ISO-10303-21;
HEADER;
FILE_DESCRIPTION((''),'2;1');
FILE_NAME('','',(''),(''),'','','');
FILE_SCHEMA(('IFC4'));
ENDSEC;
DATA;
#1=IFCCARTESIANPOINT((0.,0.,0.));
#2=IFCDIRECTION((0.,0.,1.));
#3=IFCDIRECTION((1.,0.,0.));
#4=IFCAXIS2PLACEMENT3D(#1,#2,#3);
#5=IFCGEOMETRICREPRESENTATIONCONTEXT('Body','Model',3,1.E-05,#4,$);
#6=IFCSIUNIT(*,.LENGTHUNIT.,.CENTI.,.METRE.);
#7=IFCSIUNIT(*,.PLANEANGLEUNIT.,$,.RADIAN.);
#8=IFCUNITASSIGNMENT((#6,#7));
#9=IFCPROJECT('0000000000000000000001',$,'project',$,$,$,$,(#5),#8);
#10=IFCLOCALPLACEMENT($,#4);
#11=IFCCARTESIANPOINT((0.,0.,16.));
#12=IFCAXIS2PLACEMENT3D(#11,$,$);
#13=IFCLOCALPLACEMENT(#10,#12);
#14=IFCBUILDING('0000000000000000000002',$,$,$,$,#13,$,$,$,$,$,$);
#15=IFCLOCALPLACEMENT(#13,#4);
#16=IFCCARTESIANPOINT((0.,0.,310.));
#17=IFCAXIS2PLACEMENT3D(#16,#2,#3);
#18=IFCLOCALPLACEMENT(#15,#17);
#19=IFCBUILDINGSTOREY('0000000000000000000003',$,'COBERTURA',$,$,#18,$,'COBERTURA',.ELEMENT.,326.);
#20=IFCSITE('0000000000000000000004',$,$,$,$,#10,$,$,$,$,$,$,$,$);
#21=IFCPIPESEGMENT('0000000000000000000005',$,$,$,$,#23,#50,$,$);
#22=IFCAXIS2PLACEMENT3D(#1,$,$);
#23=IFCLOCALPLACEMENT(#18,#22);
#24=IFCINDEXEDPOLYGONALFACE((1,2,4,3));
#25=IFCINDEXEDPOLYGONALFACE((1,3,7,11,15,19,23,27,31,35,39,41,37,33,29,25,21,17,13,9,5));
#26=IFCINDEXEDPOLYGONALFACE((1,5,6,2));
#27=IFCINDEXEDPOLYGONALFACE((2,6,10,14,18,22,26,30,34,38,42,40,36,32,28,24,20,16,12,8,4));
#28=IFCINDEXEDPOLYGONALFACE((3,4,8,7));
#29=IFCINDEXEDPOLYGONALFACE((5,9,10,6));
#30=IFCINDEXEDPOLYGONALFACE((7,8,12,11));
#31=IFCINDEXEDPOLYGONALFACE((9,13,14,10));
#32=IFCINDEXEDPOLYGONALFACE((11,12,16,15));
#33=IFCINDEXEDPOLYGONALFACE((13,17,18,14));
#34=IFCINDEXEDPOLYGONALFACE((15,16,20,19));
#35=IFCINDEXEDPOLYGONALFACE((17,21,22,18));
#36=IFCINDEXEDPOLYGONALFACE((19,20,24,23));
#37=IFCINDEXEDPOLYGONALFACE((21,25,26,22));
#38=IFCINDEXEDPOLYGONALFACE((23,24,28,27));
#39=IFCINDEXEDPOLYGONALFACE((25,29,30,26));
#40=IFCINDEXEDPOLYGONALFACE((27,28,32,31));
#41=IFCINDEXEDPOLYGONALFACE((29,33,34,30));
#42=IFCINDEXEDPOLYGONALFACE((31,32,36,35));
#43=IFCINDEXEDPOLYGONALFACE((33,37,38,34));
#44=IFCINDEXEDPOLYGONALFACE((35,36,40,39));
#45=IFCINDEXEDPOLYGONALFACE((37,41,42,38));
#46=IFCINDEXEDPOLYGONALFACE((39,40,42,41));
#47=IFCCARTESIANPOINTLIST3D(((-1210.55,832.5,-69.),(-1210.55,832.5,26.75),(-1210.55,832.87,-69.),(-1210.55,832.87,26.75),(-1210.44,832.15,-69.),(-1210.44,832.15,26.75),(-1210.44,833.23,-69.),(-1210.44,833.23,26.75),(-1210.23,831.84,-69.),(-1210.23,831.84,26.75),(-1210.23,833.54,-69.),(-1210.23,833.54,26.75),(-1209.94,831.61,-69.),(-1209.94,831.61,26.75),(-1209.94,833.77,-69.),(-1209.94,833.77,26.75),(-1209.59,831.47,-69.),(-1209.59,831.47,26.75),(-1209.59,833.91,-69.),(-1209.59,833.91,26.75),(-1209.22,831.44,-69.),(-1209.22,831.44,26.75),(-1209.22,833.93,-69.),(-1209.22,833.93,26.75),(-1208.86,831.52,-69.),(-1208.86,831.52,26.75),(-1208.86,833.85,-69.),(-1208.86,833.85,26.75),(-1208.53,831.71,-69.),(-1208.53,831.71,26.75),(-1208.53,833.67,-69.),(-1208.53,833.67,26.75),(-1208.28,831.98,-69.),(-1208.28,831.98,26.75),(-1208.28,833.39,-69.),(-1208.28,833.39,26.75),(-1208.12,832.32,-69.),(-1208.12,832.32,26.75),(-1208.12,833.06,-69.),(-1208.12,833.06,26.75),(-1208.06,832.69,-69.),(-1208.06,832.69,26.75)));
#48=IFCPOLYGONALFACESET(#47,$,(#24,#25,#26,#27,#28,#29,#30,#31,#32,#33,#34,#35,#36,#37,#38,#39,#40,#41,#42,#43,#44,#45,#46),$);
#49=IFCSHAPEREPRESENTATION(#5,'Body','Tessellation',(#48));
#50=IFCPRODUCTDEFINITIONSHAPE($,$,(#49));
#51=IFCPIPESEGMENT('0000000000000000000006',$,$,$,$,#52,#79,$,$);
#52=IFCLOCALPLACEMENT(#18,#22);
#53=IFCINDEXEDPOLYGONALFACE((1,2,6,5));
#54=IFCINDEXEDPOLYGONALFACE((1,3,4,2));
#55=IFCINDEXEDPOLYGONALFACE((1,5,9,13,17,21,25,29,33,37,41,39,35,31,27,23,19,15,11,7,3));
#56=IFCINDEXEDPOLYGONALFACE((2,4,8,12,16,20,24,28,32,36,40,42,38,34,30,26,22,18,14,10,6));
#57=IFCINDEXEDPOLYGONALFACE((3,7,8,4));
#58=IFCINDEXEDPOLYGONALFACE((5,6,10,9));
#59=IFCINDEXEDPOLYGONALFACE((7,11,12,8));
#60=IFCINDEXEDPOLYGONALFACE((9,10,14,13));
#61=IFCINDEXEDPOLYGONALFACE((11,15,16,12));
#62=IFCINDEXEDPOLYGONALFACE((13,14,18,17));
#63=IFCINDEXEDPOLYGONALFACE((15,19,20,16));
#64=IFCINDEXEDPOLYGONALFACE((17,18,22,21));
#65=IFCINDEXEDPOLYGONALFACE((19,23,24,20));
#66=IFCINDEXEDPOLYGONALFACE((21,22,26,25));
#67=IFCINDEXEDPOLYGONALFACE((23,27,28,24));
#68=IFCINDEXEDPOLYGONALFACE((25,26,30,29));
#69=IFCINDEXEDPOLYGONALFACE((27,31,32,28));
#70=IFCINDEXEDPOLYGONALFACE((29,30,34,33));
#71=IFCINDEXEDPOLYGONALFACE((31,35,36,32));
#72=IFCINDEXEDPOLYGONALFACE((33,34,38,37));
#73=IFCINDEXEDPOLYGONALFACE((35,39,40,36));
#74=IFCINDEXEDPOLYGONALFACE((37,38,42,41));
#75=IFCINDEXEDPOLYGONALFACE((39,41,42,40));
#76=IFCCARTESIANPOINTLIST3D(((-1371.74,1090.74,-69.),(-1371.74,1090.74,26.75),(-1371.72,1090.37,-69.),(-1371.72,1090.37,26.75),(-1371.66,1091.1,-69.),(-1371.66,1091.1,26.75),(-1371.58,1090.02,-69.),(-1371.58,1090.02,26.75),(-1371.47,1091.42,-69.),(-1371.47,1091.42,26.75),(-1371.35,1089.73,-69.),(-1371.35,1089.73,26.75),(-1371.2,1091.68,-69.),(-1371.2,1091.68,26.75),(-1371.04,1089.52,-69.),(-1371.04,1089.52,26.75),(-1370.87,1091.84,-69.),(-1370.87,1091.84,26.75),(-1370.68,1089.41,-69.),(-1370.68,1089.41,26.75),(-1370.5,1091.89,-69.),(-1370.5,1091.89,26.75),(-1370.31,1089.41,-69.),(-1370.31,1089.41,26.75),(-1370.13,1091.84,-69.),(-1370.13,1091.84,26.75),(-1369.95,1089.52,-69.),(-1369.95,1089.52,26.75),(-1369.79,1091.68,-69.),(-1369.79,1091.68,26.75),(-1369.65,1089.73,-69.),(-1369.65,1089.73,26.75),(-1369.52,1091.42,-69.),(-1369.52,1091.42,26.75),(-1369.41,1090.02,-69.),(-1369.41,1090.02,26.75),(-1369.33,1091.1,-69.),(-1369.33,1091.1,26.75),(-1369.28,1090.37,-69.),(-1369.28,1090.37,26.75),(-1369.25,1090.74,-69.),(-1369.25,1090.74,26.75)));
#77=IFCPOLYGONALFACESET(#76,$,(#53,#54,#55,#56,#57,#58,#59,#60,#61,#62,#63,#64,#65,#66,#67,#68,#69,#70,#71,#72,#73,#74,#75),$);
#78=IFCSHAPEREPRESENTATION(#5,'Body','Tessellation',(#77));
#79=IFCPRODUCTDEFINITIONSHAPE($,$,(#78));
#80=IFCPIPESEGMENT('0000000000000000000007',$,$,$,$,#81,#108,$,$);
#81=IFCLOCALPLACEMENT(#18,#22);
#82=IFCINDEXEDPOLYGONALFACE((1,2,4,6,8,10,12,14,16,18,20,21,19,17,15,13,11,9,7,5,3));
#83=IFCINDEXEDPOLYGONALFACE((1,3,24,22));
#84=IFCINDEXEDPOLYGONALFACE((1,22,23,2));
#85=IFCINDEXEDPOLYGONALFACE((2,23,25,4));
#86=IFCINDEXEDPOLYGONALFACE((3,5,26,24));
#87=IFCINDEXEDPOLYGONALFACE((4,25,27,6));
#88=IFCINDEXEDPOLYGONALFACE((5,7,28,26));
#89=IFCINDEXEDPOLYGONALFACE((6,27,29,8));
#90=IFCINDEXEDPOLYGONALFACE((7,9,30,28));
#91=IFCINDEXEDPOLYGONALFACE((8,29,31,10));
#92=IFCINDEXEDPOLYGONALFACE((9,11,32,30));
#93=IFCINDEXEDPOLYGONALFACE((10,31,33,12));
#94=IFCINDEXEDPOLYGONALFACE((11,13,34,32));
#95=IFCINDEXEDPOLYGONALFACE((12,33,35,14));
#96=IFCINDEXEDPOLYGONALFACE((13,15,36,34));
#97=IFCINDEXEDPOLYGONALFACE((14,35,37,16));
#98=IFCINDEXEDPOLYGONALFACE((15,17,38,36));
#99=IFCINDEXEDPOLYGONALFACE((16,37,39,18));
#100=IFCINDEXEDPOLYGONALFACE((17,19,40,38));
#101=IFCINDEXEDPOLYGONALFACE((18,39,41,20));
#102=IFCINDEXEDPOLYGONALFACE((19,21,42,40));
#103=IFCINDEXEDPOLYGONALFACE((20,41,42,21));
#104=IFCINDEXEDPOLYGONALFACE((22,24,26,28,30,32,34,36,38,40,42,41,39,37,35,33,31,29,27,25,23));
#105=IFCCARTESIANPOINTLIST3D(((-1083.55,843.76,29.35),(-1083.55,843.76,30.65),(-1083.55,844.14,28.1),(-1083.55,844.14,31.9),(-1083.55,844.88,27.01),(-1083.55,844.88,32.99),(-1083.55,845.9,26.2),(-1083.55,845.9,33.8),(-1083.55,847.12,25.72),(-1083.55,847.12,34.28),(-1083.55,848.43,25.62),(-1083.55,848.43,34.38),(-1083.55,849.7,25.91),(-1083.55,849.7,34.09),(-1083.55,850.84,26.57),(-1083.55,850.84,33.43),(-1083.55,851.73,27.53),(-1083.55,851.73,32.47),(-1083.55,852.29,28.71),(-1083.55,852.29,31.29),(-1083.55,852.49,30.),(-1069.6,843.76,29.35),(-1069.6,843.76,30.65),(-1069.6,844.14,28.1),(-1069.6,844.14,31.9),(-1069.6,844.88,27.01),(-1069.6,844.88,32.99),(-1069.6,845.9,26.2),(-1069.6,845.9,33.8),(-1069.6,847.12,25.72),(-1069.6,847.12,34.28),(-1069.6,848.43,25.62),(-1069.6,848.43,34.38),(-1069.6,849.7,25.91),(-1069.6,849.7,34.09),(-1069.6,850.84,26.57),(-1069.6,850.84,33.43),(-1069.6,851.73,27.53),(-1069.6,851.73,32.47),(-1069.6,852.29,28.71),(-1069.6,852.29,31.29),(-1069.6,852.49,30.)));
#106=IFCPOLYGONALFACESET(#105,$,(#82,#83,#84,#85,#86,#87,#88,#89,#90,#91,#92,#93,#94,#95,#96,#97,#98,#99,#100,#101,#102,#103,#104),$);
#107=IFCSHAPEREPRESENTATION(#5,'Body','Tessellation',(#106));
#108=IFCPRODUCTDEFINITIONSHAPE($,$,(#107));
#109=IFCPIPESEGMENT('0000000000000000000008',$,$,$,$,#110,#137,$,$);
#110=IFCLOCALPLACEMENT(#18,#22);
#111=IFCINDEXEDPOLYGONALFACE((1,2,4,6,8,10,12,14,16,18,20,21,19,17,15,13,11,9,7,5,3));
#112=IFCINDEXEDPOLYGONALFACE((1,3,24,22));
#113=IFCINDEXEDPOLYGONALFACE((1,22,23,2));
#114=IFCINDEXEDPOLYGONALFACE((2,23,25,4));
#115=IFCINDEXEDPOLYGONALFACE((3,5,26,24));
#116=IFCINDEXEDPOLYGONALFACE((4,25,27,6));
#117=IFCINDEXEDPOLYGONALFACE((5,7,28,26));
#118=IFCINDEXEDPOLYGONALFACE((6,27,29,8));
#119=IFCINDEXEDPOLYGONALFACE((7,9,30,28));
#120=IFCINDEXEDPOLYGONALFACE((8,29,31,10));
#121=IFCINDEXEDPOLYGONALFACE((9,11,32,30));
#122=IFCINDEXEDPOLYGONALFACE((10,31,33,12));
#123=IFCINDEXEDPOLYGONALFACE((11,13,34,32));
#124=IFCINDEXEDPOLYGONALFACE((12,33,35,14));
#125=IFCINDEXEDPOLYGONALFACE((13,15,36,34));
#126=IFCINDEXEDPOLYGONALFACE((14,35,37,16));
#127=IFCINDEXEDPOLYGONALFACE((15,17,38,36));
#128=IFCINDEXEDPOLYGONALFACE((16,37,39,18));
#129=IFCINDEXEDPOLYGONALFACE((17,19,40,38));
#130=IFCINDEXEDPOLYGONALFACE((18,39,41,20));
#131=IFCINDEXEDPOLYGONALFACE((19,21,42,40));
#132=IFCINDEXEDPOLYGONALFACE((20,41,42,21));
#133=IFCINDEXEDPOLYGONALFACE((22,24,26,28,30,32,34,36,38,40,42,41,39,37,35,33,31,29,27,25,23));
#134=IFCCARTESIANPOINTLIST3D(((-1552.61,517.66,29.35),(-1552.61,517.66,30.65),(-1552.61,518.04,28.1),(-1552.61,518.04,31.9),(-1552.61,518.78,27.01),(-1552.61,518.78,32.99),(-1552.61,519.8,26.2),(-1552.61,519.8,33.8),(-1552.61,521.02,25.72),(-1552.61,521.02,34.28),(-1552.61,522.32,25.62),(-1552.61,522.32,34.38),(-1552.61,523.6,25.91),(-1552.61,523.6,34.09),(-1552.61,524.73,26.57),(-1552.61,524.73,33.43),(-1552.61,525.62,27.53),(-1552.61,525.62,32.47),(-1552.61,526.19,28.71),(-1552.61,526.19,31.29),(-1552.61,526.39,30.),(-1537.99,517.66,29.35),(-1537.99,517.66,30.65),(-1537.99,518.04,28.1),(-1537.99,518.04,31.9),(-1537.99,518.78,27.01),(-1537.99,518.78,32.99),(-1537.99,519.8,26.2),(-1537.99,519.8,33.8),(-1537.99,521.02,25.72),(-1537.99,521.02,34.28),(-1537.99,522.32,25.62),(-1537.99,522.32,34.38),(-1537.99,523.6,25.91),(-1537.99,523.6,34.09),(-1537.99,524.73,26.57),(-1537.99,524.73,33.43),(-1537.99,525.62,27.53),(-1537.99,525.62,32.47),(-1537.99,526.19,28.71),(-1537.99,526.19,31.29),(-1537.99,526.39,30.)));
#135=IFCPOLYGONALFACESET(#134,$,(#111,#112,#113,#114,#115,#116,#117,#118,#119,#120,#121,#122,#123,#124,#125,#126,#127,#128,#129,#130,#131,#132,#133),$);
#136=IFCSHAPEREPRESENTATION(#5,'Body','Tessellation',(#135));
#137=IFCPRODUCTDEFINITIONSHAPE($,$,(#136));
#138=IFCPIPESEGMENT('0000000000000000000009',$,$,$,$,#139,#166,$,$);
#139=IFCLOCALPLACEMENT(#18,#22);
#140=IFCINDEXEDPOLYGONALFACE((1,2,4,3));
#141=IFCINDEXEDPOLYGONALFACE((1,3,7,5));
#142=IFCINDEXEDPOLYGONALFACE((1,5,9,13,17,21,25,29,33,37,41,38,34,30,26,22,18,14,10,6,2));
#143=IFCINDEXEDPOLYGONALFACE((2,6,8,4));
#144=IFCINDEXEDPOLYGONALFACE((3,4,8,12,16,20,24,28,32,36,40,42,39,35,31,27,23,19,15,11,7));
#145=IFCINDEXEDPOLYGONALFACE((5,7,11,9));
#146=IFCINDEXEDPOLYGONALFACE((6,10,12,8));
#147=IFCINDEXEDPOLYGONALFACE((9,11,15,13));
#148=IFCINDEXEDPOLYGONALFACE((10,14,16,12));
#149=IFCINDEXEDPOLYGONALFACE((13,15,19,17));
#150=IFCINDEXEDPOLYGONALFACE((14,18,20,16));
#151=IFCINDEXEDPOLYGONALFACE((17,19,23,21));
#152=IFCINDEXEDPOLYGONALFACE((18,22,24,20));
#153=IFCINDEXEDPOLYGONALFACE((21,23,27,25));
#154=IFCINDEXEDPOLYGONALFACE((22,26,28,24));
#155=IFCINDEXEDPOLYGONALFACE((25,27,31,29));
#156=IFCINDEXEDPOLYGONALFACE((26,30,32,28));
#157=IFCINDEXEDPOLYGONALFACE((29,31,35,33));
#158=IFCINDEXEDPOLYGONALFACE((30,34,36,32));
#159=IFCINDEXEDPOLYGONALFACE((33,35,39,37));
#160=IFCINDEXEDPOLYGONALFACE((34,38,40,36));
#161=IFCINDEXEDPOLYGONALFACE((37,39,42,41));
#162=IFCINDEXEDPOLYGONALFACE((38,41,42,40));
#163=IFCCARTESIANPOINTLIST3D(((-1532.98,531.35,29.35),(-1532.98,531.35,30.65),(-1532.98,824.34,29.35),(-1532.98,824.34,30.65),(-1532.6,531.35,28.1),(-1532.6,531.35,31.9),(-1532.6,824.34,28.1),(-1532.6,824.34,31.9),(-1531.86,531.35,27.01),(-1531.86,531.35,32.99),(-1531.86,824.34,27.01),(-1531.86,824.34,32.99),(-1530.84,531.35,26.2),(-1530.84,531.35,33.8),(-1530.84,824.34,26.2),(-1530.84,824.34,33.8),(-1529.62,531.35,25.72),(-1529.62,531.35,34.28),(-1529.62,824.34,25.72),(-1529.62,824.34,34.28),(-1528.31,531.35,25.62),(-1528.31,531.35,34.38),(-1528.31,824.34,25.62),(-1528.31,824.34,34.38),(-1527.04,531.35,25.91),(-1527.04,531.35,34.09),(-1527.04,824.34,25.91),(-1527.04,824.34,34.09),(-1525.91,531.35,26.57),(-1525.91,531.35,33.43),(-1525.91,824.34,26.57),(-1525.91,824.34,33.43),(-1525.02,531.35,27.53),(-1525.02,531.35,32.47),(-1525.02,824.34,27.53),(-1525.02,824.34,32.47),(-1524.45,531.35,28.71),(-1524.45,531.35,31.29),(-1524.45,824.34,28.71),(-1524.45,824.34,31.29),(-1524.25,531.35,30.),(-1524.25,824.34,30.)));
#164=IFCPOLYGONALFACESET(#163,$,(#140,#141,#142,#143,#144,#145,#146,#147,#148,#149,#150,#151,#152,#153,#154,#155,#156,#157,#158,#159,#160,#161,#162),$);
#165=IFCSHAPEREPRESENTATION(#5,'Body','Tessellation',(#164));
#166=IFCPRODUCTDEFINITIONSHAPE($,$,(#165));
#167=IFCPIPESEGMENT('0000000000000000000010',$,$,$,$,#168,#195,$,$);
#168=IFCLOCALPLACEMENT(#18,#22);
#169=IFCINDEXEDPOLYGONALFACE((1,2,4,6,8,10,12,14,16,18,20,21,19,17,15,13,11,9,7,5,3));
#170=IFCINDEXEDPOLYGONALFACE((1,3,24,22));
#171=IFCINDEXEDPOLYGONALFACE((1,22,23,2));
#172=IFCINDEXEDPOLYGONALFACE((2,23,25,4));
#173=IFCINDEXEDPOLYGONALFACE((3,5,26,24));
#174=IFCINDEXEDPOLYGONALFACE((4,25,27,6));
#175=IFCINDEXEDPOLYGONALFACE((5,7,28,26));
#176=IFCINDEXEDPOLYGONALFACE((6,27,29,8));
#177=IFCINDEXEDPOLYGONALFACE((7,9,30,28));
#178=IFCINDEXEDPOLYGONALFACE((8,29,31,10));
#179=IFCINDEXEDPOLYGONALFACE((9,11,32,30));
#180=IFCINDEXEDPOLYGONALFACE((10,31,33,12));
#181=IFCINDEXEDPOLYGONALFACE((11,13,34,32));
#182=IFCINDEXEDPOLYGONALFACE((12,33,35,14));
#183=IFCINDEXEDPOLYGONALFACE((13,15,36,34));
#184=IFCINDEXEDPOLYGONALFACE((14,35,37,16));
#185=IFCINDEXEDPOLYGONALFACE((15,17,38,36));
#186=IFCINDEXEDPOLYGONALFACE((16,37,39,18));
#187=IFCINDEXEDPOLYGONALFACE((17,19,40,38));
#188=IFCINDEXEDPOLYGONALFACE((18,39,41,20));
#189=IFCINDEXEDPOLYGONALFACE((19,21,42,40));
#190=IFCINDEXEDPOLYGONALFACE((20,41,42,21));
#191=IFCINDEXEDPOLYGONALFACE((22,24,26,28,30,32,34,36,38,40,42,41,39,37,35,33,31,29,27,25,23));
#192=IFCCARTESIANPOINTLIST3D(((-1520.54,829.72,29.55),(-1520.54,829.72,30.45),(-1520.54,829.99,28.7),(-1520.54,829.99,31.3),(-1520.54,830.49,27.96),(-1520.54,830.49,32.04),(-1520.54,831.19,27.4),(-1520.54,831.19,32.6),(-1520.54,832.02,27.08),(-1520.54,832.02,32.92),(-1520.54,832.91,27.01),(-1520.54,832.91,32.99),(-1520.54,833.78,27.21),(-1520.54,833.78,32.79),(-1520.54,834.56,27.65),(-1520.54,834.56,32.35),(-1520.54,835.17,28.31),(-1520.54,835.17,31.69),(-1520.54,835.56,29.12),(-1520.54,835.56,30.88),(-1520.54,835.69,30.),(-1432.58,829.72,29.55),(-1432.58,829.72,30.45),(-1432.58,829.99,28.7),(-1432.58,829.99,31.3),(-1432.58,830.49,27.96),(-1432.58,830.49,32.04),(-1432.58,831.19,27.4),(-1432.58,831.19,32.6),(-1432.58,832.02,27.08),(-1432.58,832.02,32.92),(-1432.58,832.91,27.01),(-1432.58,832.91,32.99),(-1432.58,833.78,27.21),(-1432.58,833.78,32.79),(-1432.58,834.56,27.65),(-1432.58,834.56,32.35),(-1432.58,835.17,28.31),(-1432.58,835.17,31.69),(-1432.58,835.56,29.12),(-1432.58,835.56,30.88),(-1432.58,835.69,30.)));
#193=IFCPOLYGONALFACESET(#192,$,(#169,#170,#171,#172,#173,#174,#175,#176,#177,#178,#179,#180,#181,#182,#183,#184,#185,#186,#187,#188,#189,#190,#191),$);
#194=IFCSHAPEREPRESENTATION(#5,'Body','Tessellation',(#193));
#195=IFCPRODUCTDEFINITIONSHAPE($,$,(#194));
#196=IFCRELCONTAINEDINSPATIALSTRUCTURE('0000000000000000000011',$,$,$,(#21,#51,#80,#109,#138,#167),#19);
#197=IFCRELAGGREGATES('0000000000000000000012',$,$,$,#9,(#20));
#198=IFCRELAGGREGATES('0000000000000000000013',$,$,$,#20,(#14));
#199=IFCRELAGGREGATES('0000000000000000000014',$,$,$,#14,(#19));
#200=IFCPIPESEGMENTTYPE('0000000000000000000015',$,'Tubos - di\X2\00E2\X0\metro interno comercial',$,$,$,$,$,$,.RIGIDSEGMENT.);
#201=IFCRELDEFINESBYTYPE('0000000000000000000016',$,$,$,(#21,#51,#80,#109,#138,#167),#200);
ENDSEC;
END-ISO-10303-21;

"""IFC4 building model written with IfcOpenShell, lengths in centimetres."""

from ifc_helpers import new_model, si_unit, frame, origin_with_axes, origin_2d_with_axis, place, context, project, spatial, circle, extrude, type_object, element, save


model = new_model("IFC4")

# Units and contexts
model_context = context("Model", 3, precision=1e-05, world=origin_with_axes(), identifier="Body")
ifc_project = project(units=[si_unit("LENGTHUNIT", "METRE", prefix="CENTI"), si_unit("PLANEANGLEUNIT", "RADIAN")], contexts=[model_context])

# Site, building, storey
site_placement = place(None, origin_with_axes())
site = spatial("IfcSite", under=ifc_project, at=site_placement)
building_placement = place(site_placement, frame((0.0, 0.0, 16.0)))
building = spatial("IfcBuilding", under=site, at=building_placement)
placement = place(building_placement, origin_with_axes())
storey_placement = place(placement, frame((0.0, 0.0, 310.0), z_axis=(0.0, 0.0, 1.0), x_axis=(1.0, 0.0, 0.0)))
storey = spatial("IfcBuildingStorey", under=building, at=storey_placement, Name="COBERTURA", LongName="COBERTURA", CompositionType="ELEMENT", Elevation=326.0)

# Pipe segments
pipe_segment_type = type_object("IfcPipeSegmentType", Name="Tubos - diâmetro interno comercial", PredefinedType="RIGIDSEGMENT")
for number, where, z_axis, x_axis in (
    (1, (-1209.31, 832.69, 26.75), (0.0, 0.0, 1.0), (1.0, 0.0, 0.0)),
):
    element("IfcPipeSegment", number, at=place(storey_placement, frame(where, z_axis=z_axis, x_axis=x_axis)), inside=storey, type_object=pipe_segment_type, context=model_context, shape_type="SolidModel", body=[
        extrude(circle(Radius=1.25, at=origin_2d_with_axis()), frame((0.0, 0.0, 0.0), z_axis=(0.0, 0.0, -1.0), x_axis=(1.0, 0.0, 0.0)), (0.0, 0.0, 1.0), 95.75),
    ])
pipe_segment_1_placement = place(storey_placement, frame((-1370.5, 1090.64, 26.75), z_axis=(0.0, 0.0, 1.0), x_axis=(1.0, 0.0, 0.0)))
element("IfcPipeSegment", 2, at=pipe_segment_1_placement, inside=storey, type_object=pipe_segment_type, context=model_context, shape_type="SolidModel", body=[
    extrude(circle(Radius=1.25, at=origin_2d_with_axis()), frame((0.0, 0.0, 0.0), z_axis=(0.0, 0.0, -1.0), x_axis=(0.0, 1.0, 0.0)), (0.0, 0.0, 1.0), 95.75),
])
pipe_segment_2_placement = place(storey_placement, frame((-1076.58, 848.1, 34.39), z_axis=(0.0, 0.0, 1.0), x_axis=(1.0, 0.0, 0.0)))
element("IfcPipeSegment", 3, at=pipe_segment_2_placement, inside=storey, type_object=pipe_segment_type, context=model_context, shape_type="SolidModel", body=[
    extrude(circle(Radius=4.39, at=origin_2d_with_axis()), frame((-6.97, 0.0, -4.39), z_axis=(1.0, 0.0, 0.0), x_axis=(0.0, 1.0, 0.0)), (0.0, 0.0, 1.0), 13.94),
])
pipe_segment_3_placement = place(storey_placement, frame((-1545.3, 522.0, 34.39), z_axis=(0.0, 0.0, 1.0), x_axis=(1.0, 0.0, 0.0)))
element("IfcPipeSegment", 4, at=pipe_segment_3_placement, inside=storey, type_object=pipe_segment_type, context=model_context, shape_type="SolidModel", body=[
    extrude(circle(Radius=4.39, at=origin_2d_with_axis()), frame((7.31, 0.0, -4.39), z_axis=(-1.0, 0.0, 0.0), x_axis=(0.0, 1.0, 0.0)), (0.0, 0.0, 1.0), 14.62),
])
pipe_segment_4_placement = place(storey_placement, frame((-1528.64, 677.84, 34.39), z_axis=(0.0, 0.0, 1.0), x_axis=(1.0, 0.0, 0.0)))
element("IfcPipeSegment", 5, at=pipe_segment_4_placement, inside=storey, type_object=pipe_segment_type, context=model_context, shape_type="SolidModel", body=[
    extrude(circle(Radius=4.39, at=origin_2d_with_axis()), frame((0.0, 146.5, -4.39), z_axis=(0.0, -1.0, 0.0), x_axis=(1.0, 0.0, 0.0)), (0.0, 0.0, 1.0), 292.99),
])
pipe_segment_5_placement = place(storey_placement, frame((-1476.56, 832.69, 33.0), z_axis=(0.0, 0.0, 1.0), x_axis=(1.0, 0.0, 0.0)))
element("IfcPipeSegment", 6, at=pipe_segment_5_placement, inside=storey, type_object=pipe_segment_type, context=model_context, shape_type="SolidModel", body=[
    extrude(circle(Radius=3.0, at=origin_2d_with_axis()), frame((-43.98, 0.0, -3.0), z_axis=(1.0, 0.0, 0.0), x_axis=(0.0, 1.0, 0.0)), (0.0, 0.0, 1.0), 87.96),
])

save(model, "model.ifc")
